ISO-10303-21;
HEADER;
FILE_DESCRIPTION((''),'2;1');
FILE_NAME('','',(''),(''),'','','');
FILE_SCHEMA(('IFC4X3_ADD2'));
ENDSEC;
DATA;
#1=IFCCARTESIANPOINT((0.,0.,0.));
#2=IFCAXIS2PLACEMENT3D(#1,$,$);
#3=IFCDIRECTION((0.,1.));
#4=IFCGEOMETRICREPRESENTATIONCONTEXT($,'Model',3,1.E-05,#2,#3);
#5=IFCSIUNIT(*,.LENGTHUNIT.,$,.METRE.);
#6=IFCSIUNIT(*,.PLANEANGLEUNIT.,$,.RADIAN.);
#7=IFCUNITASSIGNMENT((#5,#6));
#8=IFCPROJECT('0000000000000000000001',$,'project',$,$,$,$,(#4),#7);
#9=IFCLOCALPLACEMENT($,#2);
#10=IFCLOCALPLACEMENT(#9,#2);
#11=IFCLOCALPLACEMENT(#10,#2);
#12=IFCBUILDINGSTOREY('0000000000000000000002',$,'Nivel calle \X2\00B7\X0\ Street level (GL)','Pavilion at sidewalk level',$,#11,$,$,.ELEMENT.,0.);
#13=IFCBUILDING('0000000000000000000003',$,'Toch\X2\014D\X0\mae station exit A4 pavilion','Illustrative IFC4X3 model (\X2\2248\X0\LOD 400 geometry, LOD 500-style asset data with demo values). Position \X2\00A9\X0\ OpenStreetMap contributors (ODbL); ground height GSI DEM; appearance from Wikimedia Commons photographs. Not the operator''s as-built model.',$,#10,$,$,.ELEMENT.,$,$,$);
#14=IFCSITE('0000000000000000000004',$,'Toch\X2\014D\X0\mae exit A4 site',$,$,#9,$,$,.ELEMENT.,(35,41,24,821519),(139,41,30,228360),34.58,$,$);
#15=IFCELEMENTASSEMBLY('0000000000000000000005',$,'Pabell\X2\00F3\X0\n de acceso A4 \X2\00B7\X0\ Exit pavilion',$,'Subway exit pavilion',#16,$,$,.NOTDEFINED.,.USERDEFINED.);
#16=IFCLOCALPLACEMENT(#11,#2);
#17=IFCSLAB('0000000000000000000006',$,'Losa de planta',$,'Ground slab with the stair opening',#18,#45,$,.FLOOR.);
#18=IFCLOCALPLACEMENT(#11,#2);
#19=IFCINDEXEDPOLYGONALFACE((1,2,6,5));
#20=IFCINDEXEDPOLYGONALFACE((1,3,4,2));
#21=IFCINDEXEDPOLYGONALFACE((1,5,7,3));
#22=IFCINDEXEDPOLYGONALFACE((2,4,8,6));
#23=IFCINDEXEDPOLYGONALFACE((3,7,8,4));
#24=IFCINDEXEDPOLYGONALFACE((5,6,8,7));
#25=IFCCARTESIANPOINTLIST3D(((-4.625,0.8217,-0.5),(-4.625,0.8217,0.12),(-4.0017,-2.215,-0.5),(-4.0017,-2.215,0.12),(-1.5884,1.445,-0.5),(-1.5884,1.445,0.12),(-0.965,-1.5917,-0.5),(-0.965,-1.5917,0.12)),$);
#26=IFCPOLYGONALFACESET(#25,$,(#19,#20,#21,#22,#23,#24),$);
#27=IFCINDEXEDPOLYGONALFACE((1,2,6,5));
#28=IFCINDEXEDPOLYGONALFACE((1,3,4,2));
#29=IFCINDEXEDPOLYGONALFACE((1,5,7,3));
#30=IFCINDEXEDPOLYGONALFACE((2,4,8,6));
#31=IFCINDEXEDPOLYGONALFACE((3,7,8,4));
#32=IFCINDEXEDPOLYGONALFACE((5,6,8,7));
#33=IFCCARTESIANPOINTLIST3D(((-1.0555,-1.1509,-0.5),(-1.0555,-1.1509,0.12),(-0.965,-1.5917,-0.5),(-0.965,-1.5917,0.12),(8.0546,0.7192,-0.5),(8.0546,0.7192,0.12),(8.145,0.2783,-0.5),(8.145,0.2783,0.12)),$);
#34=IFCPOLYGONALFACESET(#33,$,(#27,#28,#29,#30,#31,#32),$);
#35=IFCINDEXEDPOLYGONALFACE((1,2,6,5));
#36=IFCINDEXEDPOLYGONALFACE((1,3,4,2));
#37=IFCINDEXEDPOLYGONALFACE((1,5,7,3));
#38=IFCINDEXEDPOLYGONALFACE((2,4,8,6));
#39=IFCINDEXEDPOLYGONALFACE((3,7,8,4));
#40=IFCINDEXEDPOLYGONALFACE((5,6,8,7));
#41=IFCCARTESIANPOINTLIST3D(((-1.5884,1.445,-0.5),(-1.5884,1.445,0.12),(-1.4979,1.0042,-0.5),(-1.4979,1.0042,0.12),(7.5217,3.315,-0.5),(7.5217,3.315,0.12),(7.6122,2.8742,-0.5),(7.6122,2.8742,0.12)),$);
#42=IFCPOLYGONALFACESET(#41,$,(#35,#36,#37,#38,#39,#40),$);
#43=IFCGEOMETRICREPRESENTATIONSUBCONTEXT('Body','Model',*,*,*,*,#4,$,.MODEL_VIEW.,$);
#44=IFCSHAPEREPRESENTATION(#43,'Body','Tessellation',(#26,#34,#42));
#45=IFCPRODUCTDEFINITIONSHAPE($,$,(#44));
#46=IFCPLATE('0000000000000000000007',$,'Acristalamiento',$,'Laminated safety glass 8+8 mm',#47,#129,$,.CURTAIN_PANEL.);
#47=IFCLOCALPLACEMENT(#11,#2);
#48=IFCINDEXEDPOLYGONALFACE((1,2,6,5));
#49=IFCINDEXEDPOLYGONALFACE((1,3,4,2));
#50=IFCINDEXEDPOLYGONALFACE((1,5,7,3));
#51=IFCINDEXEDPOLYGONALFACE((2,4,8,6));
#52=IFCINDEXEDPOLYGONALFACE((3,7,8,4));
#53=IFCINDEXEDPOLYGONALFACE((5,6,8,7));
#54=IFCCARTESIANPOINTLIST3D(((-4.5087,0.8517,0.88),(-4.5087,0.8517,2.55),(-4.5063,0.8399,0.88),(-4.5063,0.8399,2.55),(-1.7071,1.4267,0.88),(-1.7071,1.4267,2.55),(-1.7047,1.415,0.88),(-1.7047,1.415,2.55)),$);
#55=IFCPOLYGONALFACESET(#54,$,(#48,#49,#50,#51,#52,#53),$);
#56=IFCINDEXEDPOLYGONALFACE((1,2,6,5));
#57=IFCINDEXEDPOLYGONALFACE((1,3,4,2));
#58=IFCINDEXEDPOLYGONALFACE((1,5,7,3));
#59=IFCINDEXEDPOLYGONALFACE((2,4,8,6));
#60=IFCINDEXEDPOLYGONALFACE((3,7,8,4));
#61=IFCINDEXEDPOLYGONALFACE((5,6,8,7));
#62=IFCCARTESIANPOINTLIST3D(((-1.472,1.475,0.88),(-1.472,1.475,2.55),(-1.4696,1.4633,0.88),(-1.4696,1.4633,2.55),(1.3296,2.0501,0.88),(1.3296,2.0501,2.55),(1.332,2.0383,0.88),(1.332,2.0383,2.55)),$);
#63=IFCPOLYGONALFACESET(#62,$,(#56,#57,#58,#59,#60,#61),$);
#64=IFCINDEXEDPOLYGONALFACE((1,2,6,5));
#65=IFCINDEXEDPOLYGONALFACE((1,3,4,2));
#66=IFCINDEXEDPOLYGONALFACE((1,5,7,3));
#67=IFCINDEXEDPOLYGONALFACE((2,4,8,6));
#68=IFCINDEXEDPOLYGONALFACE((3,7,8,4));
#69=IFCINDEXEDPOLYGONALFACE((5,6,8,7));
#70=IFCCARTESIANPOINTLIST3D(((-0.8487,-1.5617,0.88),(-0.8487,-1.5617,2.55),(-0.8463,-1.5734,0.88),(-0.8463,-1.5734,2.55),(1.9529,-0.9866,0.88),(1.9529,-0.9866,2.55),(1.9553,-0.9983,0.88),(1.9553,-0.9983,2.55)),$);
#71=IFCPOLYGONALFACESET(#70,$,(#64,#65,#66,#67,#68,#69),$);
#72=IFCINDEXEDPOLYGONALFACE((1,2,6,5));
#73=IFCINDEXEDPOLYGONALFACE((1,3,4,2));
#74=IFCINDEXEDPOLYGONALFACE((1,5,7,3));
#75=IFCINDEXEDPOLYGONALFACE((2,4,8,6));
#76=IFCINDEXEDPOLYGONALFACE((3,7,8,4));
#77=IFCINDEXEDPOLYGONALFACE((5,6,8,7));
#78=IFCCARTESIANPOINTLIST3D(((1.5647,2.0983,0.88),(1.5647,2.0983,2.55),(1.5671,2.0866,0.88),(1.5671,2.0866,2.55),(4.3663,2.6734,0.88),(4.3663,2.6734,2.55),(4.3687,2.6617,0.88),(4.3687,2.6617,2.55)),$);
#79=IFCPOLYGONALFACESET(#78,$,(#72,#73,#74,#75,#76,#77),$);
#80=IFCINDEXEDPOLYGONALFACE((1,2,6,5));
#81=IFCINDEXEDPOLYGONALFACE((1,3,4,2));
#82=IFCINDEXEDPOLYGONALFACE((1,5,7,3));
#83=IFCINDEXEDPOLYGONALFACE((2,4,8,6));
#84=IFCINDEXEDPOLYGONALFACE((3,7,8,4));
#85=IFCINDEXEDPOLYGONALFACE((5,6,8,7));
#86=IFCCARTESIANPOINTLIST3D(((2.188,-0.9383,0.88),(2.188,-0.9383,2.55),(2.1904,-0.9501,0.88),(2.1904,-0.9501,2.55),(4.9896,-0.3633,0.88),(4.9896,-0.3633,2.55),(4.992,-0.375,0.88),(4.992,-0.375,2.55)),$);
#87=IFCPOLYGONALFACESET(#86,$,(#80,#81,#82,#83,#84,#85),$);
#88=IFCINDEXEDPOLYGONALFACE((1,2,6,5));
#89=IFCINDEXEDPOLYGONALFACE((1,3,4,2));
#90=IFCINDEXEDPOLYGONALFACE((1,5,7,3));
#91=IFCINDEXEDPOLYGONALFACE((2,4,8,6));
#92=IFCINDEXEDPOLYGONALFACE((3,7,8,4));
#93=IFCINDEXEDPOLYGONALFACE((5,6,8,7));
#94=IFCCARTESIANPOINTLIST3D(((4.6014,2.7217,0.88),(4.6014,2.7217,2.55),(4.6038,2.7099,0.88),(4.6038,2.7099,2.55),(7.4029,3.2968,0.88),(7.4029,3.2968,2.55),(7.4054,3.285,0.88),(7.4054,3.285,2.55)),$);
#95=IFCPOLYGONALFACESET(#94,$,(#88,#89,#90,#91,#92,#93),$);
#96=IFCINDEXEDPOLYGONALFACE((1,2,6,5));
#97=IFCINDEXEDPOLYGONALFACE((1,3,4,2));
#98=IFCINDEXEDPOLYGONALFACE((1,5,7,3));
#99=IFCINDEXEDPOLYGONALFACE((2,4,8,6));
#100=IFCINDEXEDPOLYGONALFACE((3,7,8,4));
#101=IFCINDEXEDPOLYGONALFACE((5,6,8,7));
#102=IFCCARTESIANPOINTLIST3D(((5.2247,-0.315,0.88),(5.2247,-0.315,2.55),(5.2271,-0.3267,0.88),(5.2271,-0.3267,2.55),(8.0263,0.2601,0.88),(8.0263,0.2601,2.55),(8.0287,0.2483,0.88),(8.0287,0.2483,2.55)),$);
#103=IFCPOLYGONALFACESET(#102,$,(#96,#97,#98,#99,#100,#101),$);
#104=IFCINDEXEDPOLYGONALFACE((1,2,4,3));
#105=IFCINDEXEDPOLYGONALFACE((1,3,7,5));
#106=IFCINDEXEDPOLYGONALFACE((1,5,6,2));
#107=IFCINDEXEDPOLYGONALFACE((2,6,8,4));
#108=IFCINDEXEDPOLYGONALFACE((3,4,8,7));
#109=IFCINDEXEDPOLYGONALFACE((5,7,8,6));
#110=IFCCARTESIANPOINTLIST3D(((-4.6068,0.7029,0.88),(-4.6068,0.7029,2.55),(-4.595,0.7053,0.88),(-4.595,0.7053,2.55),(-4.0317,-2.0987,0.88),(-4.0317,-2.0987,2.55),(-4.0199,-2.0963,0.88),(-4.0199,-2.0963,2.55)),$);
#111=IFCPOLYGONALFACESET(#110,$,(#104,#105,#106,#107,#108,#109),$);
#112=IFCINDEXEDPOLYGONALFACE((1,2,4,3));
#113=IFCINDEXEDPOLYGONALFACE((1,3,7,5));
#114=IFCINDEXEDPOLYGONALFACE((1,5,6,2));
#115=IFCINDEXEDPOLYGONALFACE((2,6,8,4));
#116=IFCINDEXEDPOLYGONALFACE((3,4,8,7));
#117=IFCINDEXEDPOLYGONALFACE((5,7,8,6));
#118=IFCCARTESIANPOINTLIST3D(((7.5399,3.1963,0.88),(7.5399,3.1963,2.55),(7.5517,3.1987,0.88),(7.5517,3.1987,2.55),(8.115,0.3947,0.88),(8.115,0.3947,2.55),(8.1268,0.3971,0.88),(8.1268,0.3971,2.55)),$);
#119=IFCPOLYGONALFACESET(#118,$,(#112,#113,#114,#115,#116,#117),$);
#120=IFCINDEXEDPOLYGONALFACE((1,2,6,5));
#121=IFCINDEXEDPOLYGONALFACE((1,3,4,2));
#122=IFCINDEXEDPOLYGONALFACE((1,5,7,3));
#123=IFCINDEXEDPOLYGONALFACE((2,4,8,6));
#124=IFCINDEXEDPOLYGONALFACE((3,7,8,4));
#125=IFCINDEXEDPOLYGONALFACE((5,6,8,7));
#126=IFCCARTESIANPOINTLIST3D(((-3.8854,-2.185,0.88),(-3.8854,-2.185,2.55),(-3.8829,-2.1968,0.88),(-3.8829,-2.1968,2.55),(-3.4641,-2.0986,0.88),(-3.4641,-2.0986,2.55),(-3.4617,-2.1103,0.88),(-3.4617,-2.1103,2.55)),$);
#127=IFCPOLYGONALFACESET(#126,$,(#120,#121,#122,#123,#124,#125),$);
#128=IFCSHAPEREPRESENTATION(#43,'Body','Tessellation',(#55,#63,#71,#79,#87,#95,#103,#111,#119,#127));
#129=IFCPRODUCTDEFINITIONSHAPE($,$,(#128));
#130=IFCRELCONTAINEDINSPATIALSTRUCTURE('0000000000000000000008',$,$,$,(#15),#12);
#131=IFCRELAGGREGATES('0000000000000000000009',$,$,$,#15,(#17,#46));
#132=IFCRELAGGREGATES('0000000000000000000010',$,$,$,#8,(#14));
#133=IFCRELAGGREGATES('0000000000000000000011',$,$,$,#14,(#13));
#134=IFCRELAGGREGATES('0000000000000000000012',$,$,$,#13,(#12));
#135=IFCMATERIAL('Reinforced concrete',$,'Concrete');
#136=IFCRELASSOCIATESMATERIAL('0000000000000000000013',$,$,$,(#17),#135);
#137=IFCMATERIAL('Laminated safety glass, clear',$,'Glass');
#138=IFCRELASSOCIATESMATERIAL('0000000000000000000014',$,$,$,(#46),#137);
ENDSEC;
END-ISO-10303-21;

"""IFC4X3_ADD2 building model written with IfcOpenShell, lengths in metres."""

from ifc_helpers import new_model, si_unit, direction, frame, frame_2d, origin, place, context, subcontext, project, spatial, rectangle, extrude, material, element, aggregate, save


model = new_model("IFC4X3_ADD2")

# Units and contexts
model_context = context("Model", 3, precision=1e-05, world=origin(), true_north=direction((0.0, 1.0)))
body_context = subcontext(model_context, "Body", "Model", "MODEL_VIEW")
ifc_project = project(units=[si_unit("LENGTHUNIT", "METRE"), si_unit("PLANEANGLEUNIT", "RADIAN")], contexts=[model_context])

# Site, building, storey
site_placement = place(None, origin())
site = spatial("IfcSite", under=ifc_project, at=site_placement, Name="Tochōmae exit A4 site", CompositionType="ELEMENT", RefLatitude=(35, 41, 24, 821519), RefLongitude=(139, 41, 30, 228360), RefElevation=34.58)
building_placement = place(site_placement, origin())
building = spatial("IfcBuilding", under=site, at=building_placement, Name="Tochōmae station exit A4 pavilion", Description="Illustrative IFC4X3 model (≈LOD 400 geometry, LOD 500-style asset data with demo values). Position © OpenStreetMap contributors (ODbL); ground height GSI DEM; appearance from Wikimedia Commons photographs. Not the operator's as-built model.", CompositionType="ELEMENT")
storey_placement = place(building_placement, origin())
storey = spatial("IfcBuildingStorey", under=building, at=storey_placement, Name="Nivel calle · Street level (GL)", Description="Pavilion at sidewalk level", CompositionType="ELEMENT", Elevation=0.0)

# Element assembly, slab, plate
assembly_1_placement = place(building_placement, origin())
assembly_1 = element("IfcElementAssembly", 1, at=assembly_1_placement, inside=storey, Name="Pabellón de acceso A4 · Exit pavilion", ObjectType="Subway exit pavilion", AssemblyPlace="NOTDEFINED", PredefinedType="USERDEFINED")
ifc_material_1 = material(Name="Reinforced concrete", Category="Concrete")
slab_placement = place(building_placement, origin())
slab = element("IfcSlab", 2, at=slab_placement, material=ifc_material_1, Name="Losa de planta", ObjectType="Ground slab with the stair opening", PredefinedType="FLOOR", context=body_context, shape_type="SweptSolid", body=[
    extrude(rectangle(XDim=3.1, YDim=3.1, at=frame_2d((0.0, 0.0), x_axis=(0.979575, 0.201078))), frame((-2.795, -0.385, -0.5)), (0.0, 0.0, 1.0), 0.62),
    extrude(rectangle(XDim=9.3, YDim=0.45, at=frame_2d((0.0, 0.0), x_axis=(0.979575, 0.201078))), frame((3.5448, -0.4363, -0.5)), (0.0, 0.0, 1.0), 0.62),
    extrude(rectangle(XDim=9.3, YDim=0.45, at=frame_2d((0.0, 0.0), x_axis=(0.979575, 0.201078))), frame((3.0119, 2.1596, -0.5)), (0.0, 0.0, 1.0), 0.62),
])
ifc_material_2 = material(Name="Laminated safety glass, clear", Category="Glass")
plate_placement = place(building_placement, origin())
plate = element("IfcPlate", 3, at=plate_placement, material=ifc_material_2, Name="Acristalamiento", ObjectType="Laminated safety glass 8+8 mm", PredefinedType="CURTAIN_PANEL", context=body_context, shape_type="SweptSolid", body=[
    extrude(rectangle(XDim=2.86, YDim=0.012, at=frame_2d((0.0, 0.0), x_axis=(0.979575, 0.201078))), frame((-3.1067, 1.1333, 0.88)), (0.0, 0.0, 1.0), 1.67),
    extrude(rectangle(XDim=2.86, YDim=0.012, at=frame_2d((0.0, 0.0), x_axis=(0.979575, 0.201078))), frame((-0.07, 1.7567, 0.88)), (0.0, 0.0, 1.0), 1.67),
    extrude(rectangle(XDim=2.86, YDim=0.012, at=frame_2d((0.0, 0.0), x_axis=(0.979575, 0.201078))), frame((0.5533, -1.28, 0.88)), (0.0, 0.0, 1.0), 1.67),
    extrude(rectangle(XDim=2.86, YDim=0.012, at=frame_2d((0.0, 0.0), x_axis=(0.979575, 0.201078))), frame((2.9667, 2.38, 0.88)), (0.0, 0.0, 1.0), 1.67),
    extrude(rectangle(XDim=2.86, YDim=0.012, at=frame_2d((0.0, 0.0), x_axis=(0.979575, 0.201078))), frame((3.59, -0.6567, 0.88)), (0.0, 0.0, 1.0), 1.67),
    extrude(rectangle(XDim=2.86, YDim=0.012, at=frame_2d((0.0, 0.0), x_axis=(0.979575, 0.201078))), frame((6.0034, 3.0034, 0.88)), (0.0, 0.0, 1.0), 1.67),
    extrude(rectangle(XDim=2.86, YDim=0.012, at=frame_2d((0.0, 0.0), x_axis=(0.979575, 0.201078))), frame((6.6267, -0.0333, 0.88)), (0.0, 0.0, 1.0), 1.67),
    extrude(rectangle(XDim=0.012, YDim=2.86, at=frame_2d((0.0, 0.0), x_axis=(0.979575, 0.201078))), frame((-4.3134, -0.6967, 0.88)), (0.0, 0.0, 1.0), 1.67),
    extrude(rectangle(XDim=0.012, YDim=2.86, at=frame_2d((0.0, 0.0), x_axis=(0.979575, 0.201078))), frame((7.8334, 1.7967, 0.88)), (0.0, 0.0, 1.0), 1.67),
    extrude(rectangle(XDim=0.43, YDim=0.012, at=frame_2d((0.0, 0.0), x_axis=(0.979575, 0.201078))), frame((-3.6735, -2.1477, 0.88)), (0.0, 0.0, 1.0), 1.67),
])
aggregate(assembly_1, [slab, plate])

save(model, "model.ifc")
